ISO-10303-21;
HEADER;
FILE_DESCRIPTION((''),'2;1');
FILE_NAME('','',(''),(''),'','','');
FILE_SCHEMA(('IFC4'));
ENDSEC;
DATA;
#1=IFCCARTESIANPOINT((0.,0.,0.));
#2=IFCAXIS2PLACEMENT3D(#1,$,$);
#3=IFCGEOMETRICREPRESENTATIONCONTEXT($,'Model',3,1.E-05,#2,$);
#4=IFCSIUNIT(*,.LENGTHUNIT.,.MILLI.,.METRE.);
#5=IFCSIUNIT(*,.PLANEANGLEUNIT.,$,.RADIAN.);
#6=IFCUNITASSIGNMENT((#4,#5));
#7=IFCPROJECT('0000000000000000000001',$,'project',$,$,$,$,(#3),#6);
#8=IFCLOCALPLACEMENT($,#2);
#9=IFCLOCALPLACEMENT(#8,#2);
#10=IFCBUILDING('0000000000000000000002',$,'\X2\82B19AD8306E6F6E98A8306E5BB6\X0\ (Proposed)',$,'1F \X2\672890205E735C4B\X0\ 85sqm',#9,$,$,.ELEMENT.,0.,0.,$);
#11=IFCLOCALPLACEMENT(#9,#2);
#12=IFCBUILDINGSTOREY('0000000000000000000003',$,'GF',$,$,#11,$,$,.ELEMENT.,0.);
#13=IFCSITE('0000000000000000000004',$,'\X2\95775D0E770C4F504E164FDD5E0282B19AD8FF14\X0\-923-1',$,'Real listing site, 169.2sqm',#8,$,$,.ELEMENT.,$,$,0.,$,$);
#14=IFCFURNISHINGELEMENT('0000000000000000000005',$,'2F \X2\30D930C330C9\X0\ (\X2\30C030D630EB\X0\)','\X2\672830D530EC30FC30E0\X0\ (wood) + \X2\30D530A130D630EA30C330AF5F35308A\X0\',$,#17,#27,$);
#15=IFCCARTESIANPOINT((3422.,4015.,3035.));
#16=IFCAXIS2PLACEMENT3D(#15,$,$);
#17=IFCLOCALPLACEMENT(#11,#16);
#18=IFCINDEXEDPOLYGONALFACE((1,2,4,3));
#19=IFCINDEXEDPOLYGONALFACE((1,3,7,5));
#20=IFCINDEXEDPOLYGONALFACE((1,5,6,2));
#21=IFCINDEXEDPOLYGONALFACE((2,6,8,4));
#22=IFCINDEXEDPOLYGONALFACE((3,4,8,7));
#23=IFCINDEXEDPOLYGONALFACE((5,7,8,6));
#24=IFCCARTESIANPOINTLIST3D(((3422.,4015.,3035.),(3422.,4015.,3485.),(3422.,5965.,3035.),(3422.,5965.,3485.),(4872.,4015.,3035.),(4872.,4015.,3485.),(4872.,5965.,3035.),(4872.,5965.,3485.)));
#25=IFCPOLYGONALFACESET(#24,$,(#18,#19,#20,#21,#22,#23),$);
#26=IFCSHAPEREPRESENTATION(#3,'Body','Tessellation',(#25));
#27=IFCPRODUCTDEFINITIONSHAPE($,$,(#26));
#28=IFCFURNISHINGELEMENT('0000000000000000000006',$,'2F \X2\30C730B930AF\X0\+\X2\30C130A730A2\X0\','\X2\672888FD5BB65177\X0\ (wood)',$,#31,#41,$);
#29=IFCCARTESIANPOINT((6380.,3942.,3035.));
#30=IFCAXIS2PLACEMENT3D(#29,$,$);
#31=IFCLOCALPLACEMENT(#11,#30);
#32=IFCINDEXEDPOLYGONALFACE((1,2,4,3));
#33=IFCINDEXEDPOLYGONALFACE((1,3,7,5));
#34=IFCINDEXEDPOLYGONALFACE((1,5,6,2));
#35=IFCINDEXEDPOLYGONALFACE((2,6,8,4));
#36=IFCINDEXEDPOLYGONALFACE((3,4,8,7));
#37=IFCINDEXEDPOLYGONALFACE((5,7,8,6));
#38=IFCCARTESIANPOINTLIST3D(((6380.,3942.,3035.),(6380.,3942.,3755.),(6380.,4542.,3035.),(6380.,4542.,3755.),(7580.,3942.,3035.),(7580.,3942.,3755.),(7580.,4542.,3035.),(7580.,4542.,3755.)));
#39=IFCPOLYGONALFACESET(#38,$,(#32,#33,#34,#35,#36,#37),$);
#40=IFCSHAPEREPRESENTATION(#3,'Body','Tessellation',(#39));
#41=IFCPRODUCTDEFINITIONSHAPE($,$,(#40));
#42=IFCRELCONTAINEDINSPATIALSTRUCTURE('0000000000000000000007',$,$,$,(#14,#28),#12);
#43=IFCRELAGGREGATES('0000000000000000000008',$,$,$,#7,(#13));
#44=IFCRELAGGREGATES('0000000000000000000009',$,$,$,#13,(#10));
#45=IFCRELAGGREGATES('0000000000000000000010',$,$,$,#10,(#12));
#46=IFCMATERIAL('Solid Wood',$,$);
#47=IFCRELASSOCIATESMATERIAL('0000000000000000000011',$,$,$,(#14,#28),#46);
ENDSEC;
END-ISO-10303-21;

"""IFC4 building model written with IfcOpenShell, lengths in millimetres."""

from ifc_helpers import new_model, si_unit, frame, frame_2d, origin, place, context, project, spatial, rectangle, extrude, material, element, save


model = new_model("IFC4")

# Units and contexts
model_context = context("Model", 3, precision=1e-05, world=origin())
ifc_project = project(units=[si_unit("LENGTHUNIT", "METRE", prefix="MILLI"), si_unit("PLANEANGLEUNIT", "RADIAN")], contexts=[model_context])

# Site, building, storey
site_placement = place(None, origin())
site = spatial("IfcSite", under=ifc_project, at=site_placement, Name="長崎県佐世保市花高４-923-1", ObjectType="Real listing site, 169.2sqm", CompositionType="ELEMENT", RefElevation=0.0)
building_placement = place(site_placement, origin())
building = spatial("IfcBuilding", under=site, at=building_placement, Name="花高の潮風の家 (Proposed)", ObjectType="1F 木造平屋 85sqm", CompositionType="ELEMENT", ElevationOfRefHeight=0.0, ElevationOfTerrain=0.0)
storey_placement = place(building_placement, origin())
storey = spatial("IfcBuildingStorey", under=building, at=storey_placement, Name="GF", CompositionType="ELEMENT", Elevation=0.0)

# Shared definitions
ifc_material_1 = material(Name="Solid Wood")

# Furnishing elements
furnishing_1_placement = place(storey_placement, frame((3422.0, 4015.0, 3035.0)))
element("IfcFurnishingElement", 1, at=furnishing_1_placement, inside=storey, material=ifc_material_1, Name="2F ベッド (ダブル)", Description="木フレーム (wood) + ファブリック張り", context=model_context, shape_type="SweptSolid", body=[
    extrude(rectangle(XDim=1450.0, YDim=1950.0, at=frame_2d((725.0, 975.0))), frame((3422.0, 4015.0, 3035.0)), (0.0, 0.0, 1.0), 450.0),
])
furnishing_2_placement = place(storey_placement, frame((6380.0, 3942.0, 3035.0)))
element("IfcFurnishingElement", 2, at=furnishing_2_placement, inside=storey, material=ifc_material_1, Name="2F デスク+チェア", Description="木製家具 (wood)", context=model_context, shape_type="SweptSolid", body=[
    extrude(rectangle(XDim=1200.0, YDim=600.0, at=frame_2d((600.0, 300.0))), frame((6380.0, 3942.0, 3035.0)), (0.0, 0.0, 1.0), 720.0),
])

save(model, "model.ifc")
